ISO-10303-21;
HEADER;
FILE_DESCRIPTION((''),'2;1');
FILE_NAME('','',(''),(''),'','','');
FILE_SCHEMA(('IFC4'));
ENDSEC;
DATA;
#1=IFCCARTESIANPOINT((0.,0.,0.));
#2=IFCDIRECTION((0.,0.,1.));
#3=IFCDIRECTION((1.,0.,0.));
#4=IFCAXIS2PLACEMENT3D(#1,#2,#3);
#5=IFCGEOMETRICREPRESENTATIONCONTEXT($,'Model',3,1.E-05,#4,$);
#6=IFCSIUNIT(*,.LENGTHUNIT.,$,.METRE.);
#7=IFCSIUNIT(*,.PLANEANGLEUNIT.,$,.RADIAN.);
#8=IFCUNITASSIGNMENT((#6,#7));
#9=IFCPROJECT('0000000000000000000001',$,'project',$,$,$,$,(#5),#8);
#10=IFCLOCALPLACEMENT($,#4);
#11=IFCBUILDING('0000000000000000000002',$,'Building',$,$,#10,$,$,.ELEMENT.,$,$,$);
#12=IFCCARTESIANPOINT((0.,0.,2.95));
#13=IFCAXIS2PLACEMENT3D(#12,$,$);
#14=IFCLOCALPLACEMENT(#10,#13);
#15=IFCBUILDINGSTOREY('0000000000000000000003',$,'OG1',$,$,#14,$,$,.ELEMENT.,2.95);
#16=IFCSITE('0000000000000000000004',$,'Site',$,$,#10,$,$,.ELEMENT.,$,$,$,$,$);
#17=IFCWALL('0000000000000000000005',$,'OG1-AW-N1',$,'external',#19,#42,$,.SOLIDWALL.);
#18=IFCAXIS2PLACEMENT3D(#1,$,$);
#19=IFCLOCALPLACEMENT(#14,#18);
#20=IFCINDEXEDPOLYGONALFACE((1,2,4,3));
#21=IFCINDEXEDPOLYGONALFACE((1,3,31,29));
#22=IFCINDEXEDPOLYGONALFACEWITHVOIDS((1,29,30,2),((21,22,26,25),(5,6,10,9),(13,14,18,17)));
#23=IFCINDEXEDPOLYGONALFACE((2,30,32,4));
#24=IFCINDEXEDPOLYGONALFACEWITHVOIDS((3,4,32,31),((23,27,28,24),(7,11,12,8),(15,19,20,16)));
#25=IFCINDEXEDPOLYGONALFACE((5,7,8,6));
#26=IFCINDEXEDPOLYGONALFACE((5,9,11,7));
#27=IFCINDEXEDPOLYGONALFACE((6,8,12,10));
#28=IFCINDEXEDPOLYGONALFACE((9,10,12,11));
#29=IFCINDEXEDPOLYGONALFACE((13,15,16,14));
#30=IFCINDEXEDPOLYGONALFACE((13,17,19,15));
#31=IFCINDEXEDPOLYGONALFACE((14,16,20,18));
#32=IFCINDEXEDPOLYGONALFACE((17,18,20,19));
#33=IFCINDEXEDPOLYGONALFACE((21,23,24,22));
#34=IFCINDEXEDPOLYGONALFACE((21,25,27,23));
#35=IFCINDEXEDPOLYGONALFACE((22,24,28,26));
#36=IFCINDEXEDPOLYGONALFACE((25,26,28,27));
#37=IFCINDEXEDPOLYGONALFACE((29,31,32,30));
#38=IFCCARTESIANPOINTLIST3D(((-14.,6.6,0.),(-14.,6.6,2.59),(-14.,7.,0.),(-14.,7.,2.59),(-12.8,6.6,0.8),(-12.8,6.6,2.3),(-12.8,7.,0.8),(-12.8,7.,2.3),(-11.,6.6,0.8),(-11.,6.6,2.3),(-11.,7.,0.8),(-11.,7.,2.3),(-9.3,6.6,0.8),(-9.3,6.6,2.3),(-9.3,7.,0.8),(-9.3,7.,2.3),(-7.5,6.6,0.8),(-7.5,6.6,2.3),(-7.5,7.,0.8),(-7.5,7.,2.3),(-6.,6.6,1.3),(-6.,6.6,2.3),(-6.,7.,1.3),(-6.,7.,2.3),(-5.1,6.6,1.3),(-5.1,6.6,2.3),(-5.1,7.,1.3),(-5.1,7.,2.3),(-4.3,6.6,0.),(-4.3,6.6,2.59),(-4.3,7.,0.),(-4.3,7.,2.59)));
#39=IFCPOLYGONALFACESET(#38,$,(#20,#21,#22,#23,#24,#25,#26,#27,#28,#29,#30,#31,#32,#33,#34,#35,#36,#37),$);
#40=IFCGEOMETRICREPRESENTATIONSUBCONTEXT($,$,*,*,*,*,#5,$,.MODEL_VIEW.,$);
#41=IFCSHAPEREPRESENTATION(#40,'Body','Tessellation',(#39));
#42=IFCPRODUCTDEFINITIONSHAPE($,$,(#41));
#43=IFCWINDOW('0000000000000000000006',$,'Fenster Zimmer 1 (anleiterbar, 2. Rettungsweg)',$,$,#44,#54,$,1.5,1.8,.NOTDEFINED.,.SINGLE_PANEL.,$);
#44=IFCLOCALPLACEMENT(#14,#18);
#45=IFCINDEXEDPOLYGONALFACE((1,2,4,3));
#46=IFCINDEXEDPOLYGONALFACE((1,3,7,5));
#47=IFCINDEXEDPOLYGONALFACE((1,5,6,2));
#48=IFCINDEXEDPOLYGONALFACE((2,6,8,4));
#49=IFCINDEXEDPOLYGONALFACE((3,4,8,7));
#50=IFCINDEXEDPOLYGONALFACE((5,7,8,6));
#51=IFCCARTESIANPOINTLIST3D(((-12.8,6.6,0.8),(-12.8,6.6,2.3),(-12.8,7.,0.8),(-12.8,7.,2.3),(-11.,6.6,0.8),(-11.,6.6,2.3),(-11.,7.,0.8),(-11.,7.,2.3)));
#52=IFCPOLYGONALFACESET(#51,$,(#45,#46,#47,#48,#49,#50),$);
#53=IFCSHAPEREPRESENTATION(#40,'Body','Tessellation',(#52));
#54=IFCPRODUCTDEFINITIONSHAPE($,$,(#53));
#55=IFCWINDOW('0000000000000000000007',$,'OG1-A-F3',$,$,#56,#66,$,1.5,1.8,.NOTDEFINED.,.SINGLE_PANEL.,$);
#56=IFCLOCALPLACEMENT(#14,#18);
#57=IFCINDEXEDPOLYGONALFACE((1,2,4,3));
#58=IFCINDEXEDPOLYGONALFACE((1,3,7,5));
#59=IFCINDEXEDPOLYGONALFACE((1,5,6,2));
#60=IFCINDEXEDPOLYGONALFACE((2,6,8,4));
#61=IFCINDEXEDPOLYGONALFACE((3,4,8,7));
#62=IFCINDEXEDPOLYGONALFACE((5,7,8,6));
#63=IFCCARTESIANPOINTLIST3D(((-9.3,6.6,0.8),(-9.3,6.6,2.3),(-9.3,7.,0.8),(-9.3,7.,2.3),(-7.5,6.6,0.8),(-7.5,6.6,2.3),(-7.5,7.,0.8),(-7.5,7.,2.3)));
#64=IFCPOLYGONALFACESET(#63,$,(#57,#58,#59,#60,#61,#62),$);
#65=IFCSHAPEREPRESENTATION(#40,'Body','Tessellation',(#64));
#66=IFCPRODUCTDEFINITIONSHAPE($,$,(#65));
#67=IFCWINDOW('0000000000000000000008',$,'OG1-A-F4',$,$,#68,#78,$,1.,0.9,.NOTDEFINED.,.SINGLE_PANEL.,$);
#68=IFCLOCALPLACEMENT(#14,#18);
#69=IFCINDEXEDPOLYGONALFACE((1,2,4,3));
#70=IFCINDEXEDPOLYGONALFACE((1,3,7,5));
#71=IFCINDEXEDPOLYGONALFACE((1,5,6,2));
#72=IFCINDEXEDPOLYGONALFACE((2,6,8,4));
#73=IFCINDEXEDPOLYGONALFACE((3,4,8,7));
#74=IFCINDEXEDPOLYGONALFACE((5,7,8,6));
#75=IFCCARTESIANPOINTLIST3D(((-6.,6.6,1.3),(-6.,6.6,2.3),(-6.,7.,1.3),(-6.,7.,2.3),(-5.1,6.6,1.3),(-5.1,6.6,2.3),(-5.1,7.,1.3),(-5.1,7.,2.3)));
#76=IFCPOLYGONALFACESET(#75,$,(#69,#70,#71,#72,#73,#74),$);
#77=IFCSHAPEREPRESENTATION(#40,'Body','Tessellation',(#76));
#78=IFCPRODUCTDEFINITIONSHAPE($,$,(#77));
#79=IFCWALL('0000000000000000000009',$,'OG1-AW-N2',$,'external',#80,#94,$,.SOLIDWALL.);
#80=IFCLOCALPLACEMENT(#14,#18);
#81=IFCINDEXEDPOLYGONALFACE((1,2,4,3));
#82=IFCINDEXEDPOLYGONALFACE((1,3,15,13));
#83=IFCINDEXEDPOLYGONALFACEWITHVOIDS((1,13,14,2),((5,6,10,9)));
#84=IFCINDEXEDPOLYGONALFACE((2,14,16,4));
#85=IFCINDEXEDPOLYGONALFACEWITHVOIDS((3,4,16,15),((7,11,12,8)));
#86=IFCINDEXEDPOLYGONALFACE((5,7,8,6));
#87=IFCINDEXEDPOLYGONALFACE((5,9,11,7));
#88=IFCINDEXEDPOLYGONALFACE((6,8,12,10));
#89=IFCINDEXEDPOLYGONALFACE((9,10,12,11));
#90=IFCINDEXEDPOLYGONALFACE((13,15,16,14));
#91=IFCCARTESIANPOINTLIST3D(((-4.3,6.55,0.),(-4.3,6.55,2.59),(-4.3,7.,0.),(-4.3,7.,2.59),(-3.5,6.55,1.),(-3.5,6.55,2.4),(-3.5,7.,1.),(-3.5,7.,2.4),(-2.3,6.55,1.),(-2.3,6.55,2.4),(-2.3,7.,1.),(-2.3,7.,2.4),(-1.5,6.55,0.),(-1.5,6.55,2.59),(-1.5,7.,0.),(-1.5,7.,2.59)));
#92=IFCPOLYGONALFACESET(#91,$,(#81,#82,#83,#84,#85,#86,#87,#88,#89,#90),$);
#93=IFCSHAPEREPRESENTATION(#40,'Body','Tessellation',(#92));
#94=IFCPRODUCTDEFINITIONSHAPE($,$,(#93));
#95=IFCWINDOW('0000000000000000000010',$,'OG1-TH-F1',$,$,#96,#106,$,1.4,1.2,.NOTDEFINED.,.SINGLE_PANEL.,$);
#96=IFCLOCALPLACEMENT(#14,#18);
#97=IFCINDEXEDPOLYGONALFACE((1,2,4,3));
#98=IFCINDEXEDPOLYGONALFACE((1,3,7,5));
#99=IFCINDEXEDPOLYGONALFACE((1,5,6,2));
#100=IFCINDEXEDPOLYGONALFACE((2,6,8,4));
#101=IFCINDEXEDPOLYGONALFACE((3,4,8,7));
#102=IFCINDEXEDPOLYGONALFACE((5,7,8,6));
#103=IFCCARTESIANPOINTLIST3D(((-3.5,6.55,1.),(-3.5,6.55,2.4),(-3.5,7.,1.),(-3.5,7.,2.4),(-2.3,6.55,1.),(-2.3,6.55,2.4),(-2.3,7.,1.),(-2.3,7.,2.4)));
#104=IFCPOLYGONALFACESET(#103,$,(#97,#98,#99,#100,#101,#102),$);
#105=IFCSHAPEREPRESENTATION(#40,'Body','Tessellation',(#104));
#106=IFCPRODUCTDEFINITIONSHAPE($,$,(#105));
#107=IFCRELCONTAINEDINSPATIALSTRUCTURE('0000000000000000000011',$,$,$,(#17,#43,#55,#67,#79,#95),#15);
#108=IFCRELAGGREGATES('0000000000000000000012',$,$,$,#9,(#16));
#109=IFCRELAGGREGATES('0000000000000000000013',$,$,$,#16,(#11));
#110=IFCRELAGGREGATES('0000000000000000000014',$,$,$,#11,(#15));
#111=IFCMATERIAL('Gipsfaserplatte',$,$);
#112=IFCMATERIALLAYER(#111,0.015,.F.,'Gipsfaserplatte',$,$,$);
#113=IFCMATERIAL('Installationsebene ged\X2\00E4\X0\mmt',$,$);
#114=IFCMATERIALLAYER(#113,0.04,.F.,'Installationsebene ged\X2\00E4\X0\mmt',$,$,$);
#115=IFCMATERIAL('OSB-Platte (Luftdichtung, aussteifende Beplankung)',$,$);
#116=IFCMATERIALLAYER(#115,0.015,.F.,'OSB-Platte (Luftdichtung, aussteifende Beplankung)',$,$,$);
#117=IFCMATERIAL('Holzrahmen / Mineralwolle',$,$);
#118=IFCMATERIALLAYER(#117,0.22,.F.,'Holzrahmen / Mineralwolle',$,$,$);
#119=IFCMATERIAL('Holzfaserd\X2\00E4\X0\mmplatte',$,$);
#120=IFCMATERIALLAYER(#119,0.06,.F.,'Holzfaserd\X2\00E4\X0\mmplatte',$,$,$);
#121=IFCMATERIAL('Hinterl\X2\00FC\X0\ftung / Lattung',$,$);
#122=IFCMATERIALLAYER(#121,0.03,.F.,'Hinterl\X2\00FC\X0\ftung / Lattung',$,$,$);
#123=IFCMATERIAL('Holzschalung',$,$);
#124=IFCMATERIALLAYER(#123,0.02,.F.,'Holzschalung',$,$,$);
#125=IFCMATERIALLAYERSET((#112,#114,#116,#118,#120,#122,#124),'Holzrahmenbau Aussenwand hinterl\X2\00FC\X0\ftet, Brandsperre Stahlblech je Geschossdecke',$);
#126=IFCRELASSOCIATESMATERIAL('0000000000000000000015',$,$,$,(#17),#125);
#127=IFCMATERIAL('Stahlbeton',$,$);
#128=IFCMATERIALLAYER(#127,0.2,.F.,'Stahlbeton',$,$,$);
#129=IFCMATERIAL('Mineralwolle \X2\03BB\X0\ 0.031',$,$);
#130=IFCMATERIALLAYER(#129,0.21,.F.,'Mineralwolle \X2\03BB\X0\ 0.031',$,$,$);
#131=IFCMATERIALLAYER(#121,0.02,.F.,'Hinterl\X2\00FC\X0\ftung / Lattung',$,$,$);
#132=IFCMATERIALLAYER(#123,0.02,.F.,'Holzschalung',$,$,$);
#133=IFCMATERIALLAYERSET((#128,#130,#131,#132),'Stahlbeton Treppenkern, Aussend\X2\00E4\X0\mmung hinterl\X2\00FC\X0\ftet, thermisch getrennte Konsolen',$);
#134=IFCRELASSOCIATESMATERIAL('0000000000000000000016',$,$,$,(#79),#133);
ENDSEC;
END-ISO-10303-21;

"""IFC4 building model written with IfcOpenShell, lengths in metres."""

from ifc_helpers import new_model, si_unit, frame, frame_2d, origin, origin_with_axes, place, context, subcontext, project, spatial, rectangle, extrude, material, layer, layer_set, element, fill, save


model = new_model("IFC4")

# Units and contexts
model_context = context("Model", 3, precision=1e-05, world=origin_with_axes())
sub_context = subcontext(model_context, None, None, "MODEL_VIEW")
ifc_project = project(units=[si_unit("LENGTHUNIT", "METRE"), si_unit("PLANEANGLEUNIT", "RADIAN")], contexts=[model_context])

# Site, building, storey
placement = place(None, origin_with_axes())
site = spatial("IfcSite", under=ifc_project, at=placement, Name="Site", CompositionType="ELEMENT")
building = spatial("IfcBuilding", under=site, at=placement, Name="Building", CompositionType="ELEMENT")
storey_placement = place(placement, frame((0.0, 0.0, 2.95)))
storey = spatial("IfcBuildingStorey", under=building, at=storey_placement, Name="OG1", CompositionType="ELEMENT", Elevation=2.95)

# Wall, openings, windows
ifc_material_1 = material(Name="Gipsfaserplatte")
ifc_layer_1 = layer(ifc_material_1, 0.015, ventilated=False, Name="Gipsfaserplatte")
ifc_material_2 = material(Name="Installationsebene gedämmt")
ifc_layer_2 = layer(ifc_material_2, 0.04, ventilated=False, Name="Installationsebene gedämmt")
ifc_material_3 = material(Name="OSB-Platte (Luftdichtung, aussteifende Beplankung)")
ifc_layer_3 = layer(ifc_material_3, 0.015, ventilated=False, Name="OSB-Platte (Luftdichtung, aussteifende Beplankung)")
ifc_material_4 = material(Name="Holzrahmen / Mineralwolle")
ifc_layer_4 = layer(ifc_material_4, 0.22, ventilated=False, Name="Holzrahmen / Mineralwolle")
ifc_material_5 = material(Name="Holzfaserdämmplatte")
ifc_layer_5 = layer(ifc_material_5, 0.06, ventilated=False, Name="Holzfaserdämmplatte")
ifc_material_6 = material(Name="Hinterlüftung / Lattung")
ifc_layer_6 = layer(ifc_material_6, 0.03, ventilated=False, Name="Hinterlüftung / Lattung")
ifc_material_7 = material(Name="Holzschalung")
ifc_layer_7 = layer(ifc_material_7, 0.02, ventilated=False, Name="Holzschalung")
ifc_layer_set_1 = layer_set([ifc_layer_1, ifc_layer_2, ifc_layer_3, ifc_layer_4, ifc_layer_5, ifc_layer_6, ifc_layer_7], Name="Holzrahmenbau Aussenwand hinterlüftet, Brandsperre Stahlblech je Geschossdecke")
wall_1_placement = place(storey_placement, frame((-14.0, 6.8, 0.0), z_axis=(0.0, 0.0, 1.0), x_axis=(1.0, 0.0, 0.0)))
wall_1 = element("IfcWall", 1, at=wall_1_placement, inside=storey, material=ifc_layer_set_1, Name="OG1-AW-N1", ObjectType="external", PredefinedType="SOLIDWALL", context=sub_context, shape_type="SweptSolid", body=[
    extrude(rectangle(XDim=9.7, YDim=0.4, at=frame_2d((4.85, 0.0))), origin(), (0.0, 0.0, 1.0), 2.59),
])
opening_1_placement = place(wall_1_placement, frame((2.1, 0.25, 0.8), z_axis=(0.0, -1.0, 0.0), x_axis=(1.0, 0.0, 0.0)))
opening_1 = element("IfcOpeningElement", 2, at=opening_1_placement, cuts=wall_1, PredefinedType="OPENING", context=sub_context, shape_type="SweptSolid", body=[
    extrude(rectangle(XDim=1.8, YDim=1.5, at=frame_2d((0.0, 0.75))), origin(), (0.0, 0.0, 1.0), 0.5),
])
opening_2_placement = place(wall_1_placement, frame((5.6, 0.25, 0.8), z_axis=(0.0, -1.0, 0.0), x_axis=(1.0, 0.0, 0.0)))
opening_2 = element("IfcOpeningElement", 3, at=opening_2_placement, cuts=wall_1, PredefinedType="OPENING", context=sub_context, shape_type="SweptSolid", body=[
    extrude(rectangle(XDim=1.8, YDim=1.5, at=frame_2d((0.0, 0.75))), origin(), (0.0, 0.0, 1.0), 0.5),
])
opening_3_placement = place(wall_1_placement, frame((8.45, 0.25, 1.3), z_axis=(0.0, -1.0, 0.0), x_axis=(1.0, 0.0, 0.0)))
opening_3 = element("IfcOpeningElement", 4, at=opening_3_placement, cuts=wall_1, PredefinedType="OPENING", context=sub_context, shape_type="SweptSolid", body=[
    extrude(rectangle(XDim=0.9, YDim=1.0, at=frame_2d((0.0, 0.5))), origin(), (0.0, 0.0, 1.0), 0.5),
])
window_1_placement = place(wall_1_placement, frame((2.1, 0.2, 0.8), z_axis=(0.0, -1.0, 0.0), x_axis=(1.0, 0.0, 0.0)))
window_1 = element("IfcWindow", 5, at=window_1_placement, inside=storey, Name="Fenster Zimmer 1 (anleiterbar, 2. Rettungsweg)", OverallHeight=1.5, OverallWidth=1.8, PartitioningType="SINGLE_PANEL", PredefinedType="NOTDEFINED", context=sub_context, shape_type="SweptSolid", body=[
    extrude(rectangle(XDim=1.8, YDim=1.5, at=frame_2d((0.0, 0.75))), origin(), (0.0, 0.0, 1.0), 0.4),
])
fill(opening_1, window_1)
window_2_placement = place(wall_1_placement, frame((5.6, 0.2, 0.8), z_axis=(0.0, -1.0, 0.0), x_axis=(1.0, 0.0, 0.0)))
window_2 = element("IfcWindow", 6, at=window_2_placement, inside=storey, Name="OG1-A-F3", OverallHeight=1.5, OverallWidth=1.8, PartitioningType="SINGLE_PANEL", PredefinedType="NOTDEFINED", context=sub_context, shape_type="SweptSolid", body=[
    extrude(rectangle(XDim=1.8, YDim=1.5, at=frame_2d((0.0, 0.75))), origin(), (0.0, 0.0, 1.0), 0.4),
])
fill(opening_2, window_2)
window_3_placement = place(wall_1_placement, frame((8.45, 0.2, 1.3), z_axis=(0.0, -1.0, 0.0), x_axis=(1.0, 0.0, 0.0)))
window_3 = element("IfcWindow", 7, at=window_3_placement, inside=storey, Name="OG1-A-F4", OverallHeight=1.0, OverallWidth=0.9, PartitioningType="SINGLE_PANEL", PredefinedType="NOTDEFINED", context=sub_context, shape_type="SweptSolid", body=[
    extrude(rectangle(XDim=0.9, YDim=1.0, at=frame_2d((0.0, 0.5))), origin(), (0.0, 0.0, 1.0), 0.4),
])
fill(opening_3, window_3)

# Wall, opening, window
ifc_material_8 = material(Name="Stahlbeton")
ifc_layer_8 = layer(ifc_material_8, 0.2, ventilated=False, Name="Stahlbeton")
ifc_material_9 = material(Name="Mineralwolle λ 0.031")
ifc_layer_9 = layer(ifc_material_9, 0.21, ventilated=False, Name="Mineralwolle λ 0.031")
ifc_layer_10 = layer(ifc_material_6, 0.02, ventilated=False, Name="Hinterlüftung / Lattung")
ifc_layer_11 = layer(ifc_material_7, 0.02, ventilated=False, Name="Holzschalung")
ifc_layer_set_2 = layer_set([ifc_layer_8, ifc_layer_9, ifc_layer_10, ifc_layer_11], Name="Stahlbeton Treppenkern, Aussendämmung hinterlüftet, thermisch getrennte Konsolen")
wall_2_placement = place(storey_placement, frame((-4.3, 6.775, 0.0), z_axis=(0.0, 0.0, 1.0), x_axis=(1.0, 0.0, 0.0)))
wall_2 = element("IfcWall", 8, at=wall_2_placement, inside=storey, material=ifc_layer_set_2, Name="OG1-AW-N2", ObjectType="external", PredefinedType="SOLIDWALL", context=sub_context, shape_type="SweptSolid", body=[
    extrude(rectangle(XDim=2.8, YDim=0.45, at=frame_2d((1.4, 0.0))), origin(), (0.0, 0.0, 1.0), 2.59),
])
opening_4_placement = place(wall_2_placement, frame((1.4, 0.275, 1.0), z_axis=(0.0, -1.0, 0.0), x_axis=(1.0, 0.0, 0.0)))
opening_4 = element("IfcOpeningElement", 9, at=opening_4_placement, cuts=wall_2, PredefinedType="OPENING", context=sub_context, shape_type="SweptSolid", body=[
    extrude(rectangle(XDim=1.2, YDim=1.4, at=frame_2d((0.0, 0.7))), origin(), (0.0, 0.0, 1.0), 0.55),
])
window_4_placement = place(wall_2_placement, frame((1.4, 0.225, 1.0), z_axis=(0.0, -1.0, 0.0), x_axis=(1.0, 0.0, 0.0)))
window_4 = element("IfcWindow", 10, at=window_4_placement, inside=storey, Name="OG1-TH-F1", OverallHeight=1.4, OverallWidth=1.2, PartitioningType="SINGLE_PANEL", PredefinedType="NOTDEFINED", context=sub_context, shape_type="SweptSolid", body=[
    extrude(rectangle(XDim=1.2, YDim=1.4, at=frame_2d((0.0, 0.7))), origin(), (0.0, 0.0, 1.0), 0.45),
])
fill(opening_4, window_4)

save(model, "model.ifc")
